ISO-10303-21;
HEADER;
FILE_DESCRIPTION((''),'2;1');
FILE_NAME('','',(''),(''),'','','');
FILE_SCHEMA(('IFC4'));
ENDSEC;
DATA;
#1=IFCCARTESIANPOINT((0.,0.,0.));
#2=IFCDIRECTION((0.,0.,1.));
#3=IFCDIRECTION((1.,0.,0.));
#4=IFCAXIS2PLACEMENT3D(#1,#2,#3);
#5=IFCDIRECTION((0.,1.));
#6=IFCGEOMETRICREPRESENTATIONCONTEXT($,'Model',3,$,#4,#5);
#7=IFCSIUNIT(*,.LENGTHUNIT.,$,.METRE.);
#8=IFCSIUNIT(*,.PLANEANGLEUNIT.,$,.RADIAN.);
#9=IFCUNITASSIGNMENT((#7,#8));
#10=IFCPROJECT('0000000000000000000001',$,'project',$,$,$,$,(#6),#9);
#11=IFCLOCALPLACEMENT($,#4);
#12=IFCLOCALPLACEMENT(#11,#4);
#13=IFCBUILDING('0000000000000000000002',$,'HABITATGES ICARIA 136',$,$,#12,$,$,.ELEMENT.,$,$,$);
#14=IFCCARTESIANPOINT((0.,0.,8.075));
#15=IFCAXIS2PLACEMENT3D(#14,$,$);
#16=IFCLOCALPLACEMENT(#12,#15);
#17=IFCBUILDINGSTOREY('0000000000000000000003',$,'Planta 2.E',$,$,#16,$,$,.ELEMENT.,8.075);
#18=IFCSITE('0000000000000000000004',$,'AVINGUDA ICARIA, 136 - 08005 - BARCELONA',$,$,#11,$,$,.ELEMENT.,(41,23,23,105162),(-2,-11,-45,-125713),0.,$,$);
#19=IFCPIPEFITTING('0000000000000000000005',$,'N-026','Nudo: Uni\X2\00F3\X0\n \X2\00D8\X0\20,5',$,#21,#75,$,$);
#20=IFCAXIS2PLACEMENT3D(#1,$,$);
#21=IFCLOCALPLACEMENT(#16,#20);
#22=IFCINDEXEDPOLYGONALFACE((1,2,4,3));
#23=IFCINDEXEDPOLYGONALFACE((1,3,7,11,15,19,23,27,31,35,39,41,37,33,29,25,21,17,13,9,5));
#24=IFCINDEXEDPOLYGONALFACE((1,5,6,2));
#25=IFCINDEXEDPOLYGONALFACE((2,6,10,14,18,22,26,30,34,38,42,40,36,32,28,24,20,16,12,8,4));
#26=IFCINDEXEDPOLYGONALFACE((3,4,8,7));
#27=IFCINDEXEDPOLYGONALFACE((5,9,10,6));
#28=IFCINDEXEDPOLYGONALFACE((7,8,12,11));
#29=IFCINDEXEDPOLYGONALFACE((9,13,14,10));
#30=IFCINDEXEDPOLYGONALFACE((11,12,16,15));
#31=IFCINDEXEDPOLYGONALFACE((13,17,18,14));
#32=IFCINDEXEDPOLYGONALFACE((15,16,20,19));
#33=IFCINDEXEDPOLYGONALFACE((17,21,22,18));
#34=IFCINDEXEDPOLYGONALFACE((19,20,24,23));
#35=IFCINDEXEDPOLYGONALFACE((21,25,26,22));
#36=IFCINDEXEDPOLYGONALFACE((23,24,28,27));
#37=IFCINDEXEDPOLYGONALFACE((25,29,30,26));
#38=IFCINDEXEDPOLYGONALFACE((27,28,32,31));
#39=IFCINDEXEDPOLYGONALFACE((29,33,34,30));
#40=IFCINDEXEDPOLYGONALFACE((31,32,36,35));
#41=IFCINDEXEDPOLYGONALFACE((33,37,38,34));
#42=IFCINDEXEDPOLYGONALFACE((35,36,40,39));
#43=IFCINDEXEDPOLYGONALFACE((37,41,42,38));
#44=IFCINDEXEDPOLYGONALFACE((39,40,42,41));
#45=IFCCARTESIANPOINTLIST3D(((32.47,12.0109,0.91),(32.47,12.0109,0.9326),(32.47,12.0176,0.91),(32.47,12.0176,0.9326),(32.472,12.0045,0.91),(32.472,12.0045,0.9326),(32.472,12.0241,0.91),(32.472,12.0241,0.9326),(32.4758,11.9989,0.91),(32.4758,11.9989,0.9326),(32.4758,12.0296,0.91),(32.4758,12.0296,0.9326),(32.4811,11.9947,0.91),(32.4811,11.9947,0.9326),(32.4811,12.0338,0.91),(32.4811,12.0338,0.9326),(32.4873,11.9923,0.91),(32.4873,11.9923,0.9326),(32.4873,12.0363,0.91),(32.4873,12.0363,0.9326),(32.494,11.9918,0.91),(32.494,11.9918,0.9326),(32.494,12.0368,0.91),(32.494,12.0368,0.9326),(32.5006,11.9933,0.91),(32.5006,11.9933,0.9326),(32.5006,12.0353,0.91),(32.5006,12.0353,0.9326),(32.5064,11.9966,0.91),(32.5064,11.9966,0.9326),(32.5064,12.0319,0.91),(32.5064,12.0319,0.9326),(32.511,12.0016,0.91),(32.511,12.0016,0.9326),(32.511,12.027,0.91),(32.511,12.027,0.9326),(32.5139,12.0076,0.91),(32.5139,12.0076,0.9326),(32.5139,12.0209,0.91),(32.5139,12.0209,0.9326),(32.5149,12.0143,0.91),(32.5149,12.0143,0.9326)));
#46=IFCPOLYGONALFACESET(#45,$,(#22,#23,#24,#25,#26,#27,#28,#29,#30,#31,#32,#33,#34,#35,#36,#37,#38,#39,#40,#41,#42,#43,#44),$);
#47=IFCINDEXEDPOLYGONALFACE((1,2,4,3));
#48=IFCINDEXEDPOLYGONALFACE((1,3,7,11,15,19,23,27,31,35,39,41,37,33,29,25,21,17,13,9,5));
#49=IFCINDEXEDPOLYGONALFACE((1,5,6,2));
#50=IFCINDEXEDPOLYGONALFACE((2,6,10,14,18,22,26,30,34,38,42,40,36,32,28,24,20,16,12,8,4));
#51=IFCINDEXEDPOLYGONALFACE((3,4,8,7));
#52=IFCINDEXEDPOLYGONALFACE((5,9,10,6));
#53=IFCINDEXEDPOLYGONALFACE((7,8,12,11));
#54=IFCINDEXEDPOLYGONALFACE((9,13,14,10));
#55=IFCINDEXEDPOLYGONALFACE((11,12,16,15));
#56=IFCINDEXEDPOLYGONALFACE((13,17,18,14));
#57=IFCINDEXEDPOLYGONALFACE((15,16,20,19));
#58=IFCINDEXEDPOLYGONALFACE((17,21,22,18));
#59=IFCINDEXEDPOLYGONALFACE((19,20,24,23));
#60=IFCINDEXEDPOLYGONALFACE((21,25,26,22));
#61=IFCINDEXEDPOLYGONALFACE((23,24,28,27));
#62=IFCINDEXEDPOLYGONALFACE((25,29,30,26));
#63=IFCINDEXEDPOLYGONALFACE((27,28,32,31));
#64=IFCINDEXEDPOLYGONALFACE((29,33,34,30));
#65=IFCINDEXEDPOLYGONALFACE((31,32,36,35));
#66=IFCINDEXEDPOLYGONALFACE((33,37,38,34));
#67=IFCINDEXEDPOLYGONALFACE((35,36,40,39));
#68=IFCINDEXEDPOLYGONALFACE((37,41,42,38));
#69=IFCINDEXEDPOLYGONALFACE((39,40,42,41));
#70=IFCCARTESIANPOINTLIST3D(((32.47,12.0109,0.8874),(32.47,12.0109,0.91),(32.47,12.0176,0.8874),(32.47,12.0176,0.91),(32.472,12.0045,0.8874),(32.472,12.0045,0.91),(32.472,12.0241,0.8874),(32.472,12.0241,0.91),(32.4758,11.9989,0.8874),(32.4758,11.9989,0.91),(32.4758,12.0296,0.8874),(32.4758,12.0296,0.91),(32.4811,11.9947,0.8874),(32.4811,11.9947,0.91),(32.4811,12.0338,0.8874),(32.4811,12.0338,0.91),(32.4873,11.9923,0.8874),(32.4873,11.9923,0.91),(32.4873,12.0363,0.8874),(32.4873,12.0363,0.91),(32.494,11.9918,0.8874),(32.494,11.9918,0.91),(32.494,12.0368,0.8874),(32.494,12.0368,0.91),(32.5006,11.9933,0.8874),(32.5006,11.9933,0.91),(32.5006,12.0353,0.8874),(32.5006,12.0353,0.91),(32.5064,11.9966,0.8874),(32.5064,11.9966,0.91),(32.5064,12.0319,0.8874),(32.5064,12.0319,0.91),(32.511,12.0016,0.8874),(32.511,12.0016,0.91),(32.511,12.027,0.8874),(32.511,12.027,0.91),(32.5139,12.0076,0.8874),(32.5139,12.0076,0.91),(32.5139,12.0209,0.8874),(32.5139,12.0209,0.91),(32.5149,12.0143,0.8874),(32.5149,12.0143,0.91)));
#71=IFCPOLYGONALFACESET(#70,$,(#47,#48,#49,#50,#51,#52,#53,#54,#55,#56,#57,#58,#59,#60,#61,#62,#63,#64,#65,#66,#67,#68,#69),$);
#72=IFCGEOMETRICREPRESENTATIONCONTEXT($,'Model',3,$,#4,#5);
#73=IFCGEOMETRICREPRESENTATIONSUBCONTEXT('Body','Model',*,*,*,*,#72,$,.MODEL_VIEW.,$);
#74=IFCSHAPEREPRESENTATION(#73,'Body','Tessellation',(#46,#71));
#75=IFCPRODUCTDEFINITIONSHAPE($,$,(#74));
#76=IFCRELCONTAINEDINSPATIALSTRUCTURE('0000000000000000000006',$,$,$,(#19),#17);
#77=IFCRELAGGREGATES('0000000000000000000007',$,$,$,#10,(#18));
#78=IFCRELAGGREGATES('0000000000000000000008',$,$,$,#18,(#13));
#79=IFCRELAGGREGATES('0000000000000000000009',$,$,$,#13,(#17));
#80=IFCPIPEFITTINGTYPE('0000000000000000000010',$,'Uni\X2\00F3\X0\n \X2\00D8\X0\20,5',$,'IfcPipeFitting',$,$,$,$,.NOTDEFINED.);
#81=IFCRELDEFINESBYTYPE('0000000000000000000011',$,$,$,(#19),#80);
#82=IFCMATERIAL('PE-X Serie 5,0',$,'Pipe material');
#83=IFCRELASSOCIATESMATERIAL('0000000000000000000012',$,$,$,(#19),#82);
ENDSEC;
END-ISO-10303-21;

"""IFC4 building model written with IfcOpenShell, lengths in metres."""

from ifc_helpers import new_model, si_unit, direction, frame, origin_with_axes, origin_2d_with_axis, place, context, subcontext, project, spatial, circle, extrude, source, transform, mapped, material, type_object, element, save


model = new_model("IFC4")

# Units and contexts
model_context_1 = context("Model", 3, world=origin_with_axes(), true_north=direction((0.0, 1.0)))
model_context_2 = context("Model", 3, world=origin_with_axes(), true_north=direction((0.0, 1.0)))
body_context_1 = subcontext(model_context_2, "Body", "Model", "MODEL_VIEW")
ifc_project = project(units=[si_unit("LENGTHUNIT", "METRE"), si_unit("PLANEANGLEUNIT", "RADIAN")], contexts=[model_context_1])

# Site, building, storey
site_placement = place(None, origin_with_axes())
site = spatial("IfcSite", under=ifc_project, at=site_placement, Name="AVINGUDA ICARIA, 136 - 08005 - BARCELONA", CompositionType="ELEMENT", RefLatitude=(41, 23, 23, 105162), RefLongitude=(-2, -11, -45, -125713), RefElevation=0.0)
building_placement = place(site_placement, origin_with_axes())
building = spatial("IfcBuilding", under=site, at=building_placement, Name="HABITATGES ICARIA 136", CompositionType="ELEMENT")
storey_placement = place(building_placement, frame((0.0, 0.0, 8.075)))
storey = spatial("IfcBuildingStorey", under=building, at=storey_placement, Name="Planta 2.E", CompositionType="ELEMENT", Elevation=8.075)

# Shared definitions
ifc_material_1 = material(Name="PE-X Serie 5,0", Category="Pipe material")
placement_1 = place(None, origin_with_axes())
placement_2 = place(placement_1, origin_with_axes())
placement_3 = place(placement_2, frame((0.0, 0.0, 8.075)))

# Pipe fitting
pipe_fitting_type = type_object("IfcPipeFittingType", Name="Unión Ø20,5", ApplicableOccurrence="IfcPipeFitting", PredefinedType="NOTDEFINED")
shared_shape_1 = source(origin_with_axes(), body_context_1, "Body", "SweptSolid", [
    extrude(circle(Radius=0.0226, at=origin_2d_with_axis()), frame((0.0, 0.0, 0.0), z_axis=(0.0, 1.0, 0.0), x_axis=(-1.0, 0.0, 0.0)), (0.0, 0.0, 1.0), 0.0226),
    extrude(circle(Radius=0.0226, at=origin_2d_with_axis()), frame((0.0, -0.0226, 0.0), z_axis=(0.0, 1.0, 0.0), x_axis=(-1.0, 0.0, 0.0)), (0.0, 0.0, 1.0), 0.0226),
])
pipe_fitting_placement = place(placement_3, origin_with_axes())
element("IfcPipeFitting", 1, at=pipe_fitting_placement, inside=storey, type_object=pipe_fitting_type, material=ifc_material_1, Name="N-026", Description="Nudo: Unión Ø20,5", context=body_context_1, shape_type="MappedRepresentation", body=[
    mapped(shared_shape_1, transform((32.4923, 12.0143, 0.91), x_axis=(-1.0, 0.0, 0.0), y_axis=(0.0, 0.0, 1.0), z_axis=(0.0, 1.0, 0.0), scale=1.0)),
])

save(model, "model.ifc")
